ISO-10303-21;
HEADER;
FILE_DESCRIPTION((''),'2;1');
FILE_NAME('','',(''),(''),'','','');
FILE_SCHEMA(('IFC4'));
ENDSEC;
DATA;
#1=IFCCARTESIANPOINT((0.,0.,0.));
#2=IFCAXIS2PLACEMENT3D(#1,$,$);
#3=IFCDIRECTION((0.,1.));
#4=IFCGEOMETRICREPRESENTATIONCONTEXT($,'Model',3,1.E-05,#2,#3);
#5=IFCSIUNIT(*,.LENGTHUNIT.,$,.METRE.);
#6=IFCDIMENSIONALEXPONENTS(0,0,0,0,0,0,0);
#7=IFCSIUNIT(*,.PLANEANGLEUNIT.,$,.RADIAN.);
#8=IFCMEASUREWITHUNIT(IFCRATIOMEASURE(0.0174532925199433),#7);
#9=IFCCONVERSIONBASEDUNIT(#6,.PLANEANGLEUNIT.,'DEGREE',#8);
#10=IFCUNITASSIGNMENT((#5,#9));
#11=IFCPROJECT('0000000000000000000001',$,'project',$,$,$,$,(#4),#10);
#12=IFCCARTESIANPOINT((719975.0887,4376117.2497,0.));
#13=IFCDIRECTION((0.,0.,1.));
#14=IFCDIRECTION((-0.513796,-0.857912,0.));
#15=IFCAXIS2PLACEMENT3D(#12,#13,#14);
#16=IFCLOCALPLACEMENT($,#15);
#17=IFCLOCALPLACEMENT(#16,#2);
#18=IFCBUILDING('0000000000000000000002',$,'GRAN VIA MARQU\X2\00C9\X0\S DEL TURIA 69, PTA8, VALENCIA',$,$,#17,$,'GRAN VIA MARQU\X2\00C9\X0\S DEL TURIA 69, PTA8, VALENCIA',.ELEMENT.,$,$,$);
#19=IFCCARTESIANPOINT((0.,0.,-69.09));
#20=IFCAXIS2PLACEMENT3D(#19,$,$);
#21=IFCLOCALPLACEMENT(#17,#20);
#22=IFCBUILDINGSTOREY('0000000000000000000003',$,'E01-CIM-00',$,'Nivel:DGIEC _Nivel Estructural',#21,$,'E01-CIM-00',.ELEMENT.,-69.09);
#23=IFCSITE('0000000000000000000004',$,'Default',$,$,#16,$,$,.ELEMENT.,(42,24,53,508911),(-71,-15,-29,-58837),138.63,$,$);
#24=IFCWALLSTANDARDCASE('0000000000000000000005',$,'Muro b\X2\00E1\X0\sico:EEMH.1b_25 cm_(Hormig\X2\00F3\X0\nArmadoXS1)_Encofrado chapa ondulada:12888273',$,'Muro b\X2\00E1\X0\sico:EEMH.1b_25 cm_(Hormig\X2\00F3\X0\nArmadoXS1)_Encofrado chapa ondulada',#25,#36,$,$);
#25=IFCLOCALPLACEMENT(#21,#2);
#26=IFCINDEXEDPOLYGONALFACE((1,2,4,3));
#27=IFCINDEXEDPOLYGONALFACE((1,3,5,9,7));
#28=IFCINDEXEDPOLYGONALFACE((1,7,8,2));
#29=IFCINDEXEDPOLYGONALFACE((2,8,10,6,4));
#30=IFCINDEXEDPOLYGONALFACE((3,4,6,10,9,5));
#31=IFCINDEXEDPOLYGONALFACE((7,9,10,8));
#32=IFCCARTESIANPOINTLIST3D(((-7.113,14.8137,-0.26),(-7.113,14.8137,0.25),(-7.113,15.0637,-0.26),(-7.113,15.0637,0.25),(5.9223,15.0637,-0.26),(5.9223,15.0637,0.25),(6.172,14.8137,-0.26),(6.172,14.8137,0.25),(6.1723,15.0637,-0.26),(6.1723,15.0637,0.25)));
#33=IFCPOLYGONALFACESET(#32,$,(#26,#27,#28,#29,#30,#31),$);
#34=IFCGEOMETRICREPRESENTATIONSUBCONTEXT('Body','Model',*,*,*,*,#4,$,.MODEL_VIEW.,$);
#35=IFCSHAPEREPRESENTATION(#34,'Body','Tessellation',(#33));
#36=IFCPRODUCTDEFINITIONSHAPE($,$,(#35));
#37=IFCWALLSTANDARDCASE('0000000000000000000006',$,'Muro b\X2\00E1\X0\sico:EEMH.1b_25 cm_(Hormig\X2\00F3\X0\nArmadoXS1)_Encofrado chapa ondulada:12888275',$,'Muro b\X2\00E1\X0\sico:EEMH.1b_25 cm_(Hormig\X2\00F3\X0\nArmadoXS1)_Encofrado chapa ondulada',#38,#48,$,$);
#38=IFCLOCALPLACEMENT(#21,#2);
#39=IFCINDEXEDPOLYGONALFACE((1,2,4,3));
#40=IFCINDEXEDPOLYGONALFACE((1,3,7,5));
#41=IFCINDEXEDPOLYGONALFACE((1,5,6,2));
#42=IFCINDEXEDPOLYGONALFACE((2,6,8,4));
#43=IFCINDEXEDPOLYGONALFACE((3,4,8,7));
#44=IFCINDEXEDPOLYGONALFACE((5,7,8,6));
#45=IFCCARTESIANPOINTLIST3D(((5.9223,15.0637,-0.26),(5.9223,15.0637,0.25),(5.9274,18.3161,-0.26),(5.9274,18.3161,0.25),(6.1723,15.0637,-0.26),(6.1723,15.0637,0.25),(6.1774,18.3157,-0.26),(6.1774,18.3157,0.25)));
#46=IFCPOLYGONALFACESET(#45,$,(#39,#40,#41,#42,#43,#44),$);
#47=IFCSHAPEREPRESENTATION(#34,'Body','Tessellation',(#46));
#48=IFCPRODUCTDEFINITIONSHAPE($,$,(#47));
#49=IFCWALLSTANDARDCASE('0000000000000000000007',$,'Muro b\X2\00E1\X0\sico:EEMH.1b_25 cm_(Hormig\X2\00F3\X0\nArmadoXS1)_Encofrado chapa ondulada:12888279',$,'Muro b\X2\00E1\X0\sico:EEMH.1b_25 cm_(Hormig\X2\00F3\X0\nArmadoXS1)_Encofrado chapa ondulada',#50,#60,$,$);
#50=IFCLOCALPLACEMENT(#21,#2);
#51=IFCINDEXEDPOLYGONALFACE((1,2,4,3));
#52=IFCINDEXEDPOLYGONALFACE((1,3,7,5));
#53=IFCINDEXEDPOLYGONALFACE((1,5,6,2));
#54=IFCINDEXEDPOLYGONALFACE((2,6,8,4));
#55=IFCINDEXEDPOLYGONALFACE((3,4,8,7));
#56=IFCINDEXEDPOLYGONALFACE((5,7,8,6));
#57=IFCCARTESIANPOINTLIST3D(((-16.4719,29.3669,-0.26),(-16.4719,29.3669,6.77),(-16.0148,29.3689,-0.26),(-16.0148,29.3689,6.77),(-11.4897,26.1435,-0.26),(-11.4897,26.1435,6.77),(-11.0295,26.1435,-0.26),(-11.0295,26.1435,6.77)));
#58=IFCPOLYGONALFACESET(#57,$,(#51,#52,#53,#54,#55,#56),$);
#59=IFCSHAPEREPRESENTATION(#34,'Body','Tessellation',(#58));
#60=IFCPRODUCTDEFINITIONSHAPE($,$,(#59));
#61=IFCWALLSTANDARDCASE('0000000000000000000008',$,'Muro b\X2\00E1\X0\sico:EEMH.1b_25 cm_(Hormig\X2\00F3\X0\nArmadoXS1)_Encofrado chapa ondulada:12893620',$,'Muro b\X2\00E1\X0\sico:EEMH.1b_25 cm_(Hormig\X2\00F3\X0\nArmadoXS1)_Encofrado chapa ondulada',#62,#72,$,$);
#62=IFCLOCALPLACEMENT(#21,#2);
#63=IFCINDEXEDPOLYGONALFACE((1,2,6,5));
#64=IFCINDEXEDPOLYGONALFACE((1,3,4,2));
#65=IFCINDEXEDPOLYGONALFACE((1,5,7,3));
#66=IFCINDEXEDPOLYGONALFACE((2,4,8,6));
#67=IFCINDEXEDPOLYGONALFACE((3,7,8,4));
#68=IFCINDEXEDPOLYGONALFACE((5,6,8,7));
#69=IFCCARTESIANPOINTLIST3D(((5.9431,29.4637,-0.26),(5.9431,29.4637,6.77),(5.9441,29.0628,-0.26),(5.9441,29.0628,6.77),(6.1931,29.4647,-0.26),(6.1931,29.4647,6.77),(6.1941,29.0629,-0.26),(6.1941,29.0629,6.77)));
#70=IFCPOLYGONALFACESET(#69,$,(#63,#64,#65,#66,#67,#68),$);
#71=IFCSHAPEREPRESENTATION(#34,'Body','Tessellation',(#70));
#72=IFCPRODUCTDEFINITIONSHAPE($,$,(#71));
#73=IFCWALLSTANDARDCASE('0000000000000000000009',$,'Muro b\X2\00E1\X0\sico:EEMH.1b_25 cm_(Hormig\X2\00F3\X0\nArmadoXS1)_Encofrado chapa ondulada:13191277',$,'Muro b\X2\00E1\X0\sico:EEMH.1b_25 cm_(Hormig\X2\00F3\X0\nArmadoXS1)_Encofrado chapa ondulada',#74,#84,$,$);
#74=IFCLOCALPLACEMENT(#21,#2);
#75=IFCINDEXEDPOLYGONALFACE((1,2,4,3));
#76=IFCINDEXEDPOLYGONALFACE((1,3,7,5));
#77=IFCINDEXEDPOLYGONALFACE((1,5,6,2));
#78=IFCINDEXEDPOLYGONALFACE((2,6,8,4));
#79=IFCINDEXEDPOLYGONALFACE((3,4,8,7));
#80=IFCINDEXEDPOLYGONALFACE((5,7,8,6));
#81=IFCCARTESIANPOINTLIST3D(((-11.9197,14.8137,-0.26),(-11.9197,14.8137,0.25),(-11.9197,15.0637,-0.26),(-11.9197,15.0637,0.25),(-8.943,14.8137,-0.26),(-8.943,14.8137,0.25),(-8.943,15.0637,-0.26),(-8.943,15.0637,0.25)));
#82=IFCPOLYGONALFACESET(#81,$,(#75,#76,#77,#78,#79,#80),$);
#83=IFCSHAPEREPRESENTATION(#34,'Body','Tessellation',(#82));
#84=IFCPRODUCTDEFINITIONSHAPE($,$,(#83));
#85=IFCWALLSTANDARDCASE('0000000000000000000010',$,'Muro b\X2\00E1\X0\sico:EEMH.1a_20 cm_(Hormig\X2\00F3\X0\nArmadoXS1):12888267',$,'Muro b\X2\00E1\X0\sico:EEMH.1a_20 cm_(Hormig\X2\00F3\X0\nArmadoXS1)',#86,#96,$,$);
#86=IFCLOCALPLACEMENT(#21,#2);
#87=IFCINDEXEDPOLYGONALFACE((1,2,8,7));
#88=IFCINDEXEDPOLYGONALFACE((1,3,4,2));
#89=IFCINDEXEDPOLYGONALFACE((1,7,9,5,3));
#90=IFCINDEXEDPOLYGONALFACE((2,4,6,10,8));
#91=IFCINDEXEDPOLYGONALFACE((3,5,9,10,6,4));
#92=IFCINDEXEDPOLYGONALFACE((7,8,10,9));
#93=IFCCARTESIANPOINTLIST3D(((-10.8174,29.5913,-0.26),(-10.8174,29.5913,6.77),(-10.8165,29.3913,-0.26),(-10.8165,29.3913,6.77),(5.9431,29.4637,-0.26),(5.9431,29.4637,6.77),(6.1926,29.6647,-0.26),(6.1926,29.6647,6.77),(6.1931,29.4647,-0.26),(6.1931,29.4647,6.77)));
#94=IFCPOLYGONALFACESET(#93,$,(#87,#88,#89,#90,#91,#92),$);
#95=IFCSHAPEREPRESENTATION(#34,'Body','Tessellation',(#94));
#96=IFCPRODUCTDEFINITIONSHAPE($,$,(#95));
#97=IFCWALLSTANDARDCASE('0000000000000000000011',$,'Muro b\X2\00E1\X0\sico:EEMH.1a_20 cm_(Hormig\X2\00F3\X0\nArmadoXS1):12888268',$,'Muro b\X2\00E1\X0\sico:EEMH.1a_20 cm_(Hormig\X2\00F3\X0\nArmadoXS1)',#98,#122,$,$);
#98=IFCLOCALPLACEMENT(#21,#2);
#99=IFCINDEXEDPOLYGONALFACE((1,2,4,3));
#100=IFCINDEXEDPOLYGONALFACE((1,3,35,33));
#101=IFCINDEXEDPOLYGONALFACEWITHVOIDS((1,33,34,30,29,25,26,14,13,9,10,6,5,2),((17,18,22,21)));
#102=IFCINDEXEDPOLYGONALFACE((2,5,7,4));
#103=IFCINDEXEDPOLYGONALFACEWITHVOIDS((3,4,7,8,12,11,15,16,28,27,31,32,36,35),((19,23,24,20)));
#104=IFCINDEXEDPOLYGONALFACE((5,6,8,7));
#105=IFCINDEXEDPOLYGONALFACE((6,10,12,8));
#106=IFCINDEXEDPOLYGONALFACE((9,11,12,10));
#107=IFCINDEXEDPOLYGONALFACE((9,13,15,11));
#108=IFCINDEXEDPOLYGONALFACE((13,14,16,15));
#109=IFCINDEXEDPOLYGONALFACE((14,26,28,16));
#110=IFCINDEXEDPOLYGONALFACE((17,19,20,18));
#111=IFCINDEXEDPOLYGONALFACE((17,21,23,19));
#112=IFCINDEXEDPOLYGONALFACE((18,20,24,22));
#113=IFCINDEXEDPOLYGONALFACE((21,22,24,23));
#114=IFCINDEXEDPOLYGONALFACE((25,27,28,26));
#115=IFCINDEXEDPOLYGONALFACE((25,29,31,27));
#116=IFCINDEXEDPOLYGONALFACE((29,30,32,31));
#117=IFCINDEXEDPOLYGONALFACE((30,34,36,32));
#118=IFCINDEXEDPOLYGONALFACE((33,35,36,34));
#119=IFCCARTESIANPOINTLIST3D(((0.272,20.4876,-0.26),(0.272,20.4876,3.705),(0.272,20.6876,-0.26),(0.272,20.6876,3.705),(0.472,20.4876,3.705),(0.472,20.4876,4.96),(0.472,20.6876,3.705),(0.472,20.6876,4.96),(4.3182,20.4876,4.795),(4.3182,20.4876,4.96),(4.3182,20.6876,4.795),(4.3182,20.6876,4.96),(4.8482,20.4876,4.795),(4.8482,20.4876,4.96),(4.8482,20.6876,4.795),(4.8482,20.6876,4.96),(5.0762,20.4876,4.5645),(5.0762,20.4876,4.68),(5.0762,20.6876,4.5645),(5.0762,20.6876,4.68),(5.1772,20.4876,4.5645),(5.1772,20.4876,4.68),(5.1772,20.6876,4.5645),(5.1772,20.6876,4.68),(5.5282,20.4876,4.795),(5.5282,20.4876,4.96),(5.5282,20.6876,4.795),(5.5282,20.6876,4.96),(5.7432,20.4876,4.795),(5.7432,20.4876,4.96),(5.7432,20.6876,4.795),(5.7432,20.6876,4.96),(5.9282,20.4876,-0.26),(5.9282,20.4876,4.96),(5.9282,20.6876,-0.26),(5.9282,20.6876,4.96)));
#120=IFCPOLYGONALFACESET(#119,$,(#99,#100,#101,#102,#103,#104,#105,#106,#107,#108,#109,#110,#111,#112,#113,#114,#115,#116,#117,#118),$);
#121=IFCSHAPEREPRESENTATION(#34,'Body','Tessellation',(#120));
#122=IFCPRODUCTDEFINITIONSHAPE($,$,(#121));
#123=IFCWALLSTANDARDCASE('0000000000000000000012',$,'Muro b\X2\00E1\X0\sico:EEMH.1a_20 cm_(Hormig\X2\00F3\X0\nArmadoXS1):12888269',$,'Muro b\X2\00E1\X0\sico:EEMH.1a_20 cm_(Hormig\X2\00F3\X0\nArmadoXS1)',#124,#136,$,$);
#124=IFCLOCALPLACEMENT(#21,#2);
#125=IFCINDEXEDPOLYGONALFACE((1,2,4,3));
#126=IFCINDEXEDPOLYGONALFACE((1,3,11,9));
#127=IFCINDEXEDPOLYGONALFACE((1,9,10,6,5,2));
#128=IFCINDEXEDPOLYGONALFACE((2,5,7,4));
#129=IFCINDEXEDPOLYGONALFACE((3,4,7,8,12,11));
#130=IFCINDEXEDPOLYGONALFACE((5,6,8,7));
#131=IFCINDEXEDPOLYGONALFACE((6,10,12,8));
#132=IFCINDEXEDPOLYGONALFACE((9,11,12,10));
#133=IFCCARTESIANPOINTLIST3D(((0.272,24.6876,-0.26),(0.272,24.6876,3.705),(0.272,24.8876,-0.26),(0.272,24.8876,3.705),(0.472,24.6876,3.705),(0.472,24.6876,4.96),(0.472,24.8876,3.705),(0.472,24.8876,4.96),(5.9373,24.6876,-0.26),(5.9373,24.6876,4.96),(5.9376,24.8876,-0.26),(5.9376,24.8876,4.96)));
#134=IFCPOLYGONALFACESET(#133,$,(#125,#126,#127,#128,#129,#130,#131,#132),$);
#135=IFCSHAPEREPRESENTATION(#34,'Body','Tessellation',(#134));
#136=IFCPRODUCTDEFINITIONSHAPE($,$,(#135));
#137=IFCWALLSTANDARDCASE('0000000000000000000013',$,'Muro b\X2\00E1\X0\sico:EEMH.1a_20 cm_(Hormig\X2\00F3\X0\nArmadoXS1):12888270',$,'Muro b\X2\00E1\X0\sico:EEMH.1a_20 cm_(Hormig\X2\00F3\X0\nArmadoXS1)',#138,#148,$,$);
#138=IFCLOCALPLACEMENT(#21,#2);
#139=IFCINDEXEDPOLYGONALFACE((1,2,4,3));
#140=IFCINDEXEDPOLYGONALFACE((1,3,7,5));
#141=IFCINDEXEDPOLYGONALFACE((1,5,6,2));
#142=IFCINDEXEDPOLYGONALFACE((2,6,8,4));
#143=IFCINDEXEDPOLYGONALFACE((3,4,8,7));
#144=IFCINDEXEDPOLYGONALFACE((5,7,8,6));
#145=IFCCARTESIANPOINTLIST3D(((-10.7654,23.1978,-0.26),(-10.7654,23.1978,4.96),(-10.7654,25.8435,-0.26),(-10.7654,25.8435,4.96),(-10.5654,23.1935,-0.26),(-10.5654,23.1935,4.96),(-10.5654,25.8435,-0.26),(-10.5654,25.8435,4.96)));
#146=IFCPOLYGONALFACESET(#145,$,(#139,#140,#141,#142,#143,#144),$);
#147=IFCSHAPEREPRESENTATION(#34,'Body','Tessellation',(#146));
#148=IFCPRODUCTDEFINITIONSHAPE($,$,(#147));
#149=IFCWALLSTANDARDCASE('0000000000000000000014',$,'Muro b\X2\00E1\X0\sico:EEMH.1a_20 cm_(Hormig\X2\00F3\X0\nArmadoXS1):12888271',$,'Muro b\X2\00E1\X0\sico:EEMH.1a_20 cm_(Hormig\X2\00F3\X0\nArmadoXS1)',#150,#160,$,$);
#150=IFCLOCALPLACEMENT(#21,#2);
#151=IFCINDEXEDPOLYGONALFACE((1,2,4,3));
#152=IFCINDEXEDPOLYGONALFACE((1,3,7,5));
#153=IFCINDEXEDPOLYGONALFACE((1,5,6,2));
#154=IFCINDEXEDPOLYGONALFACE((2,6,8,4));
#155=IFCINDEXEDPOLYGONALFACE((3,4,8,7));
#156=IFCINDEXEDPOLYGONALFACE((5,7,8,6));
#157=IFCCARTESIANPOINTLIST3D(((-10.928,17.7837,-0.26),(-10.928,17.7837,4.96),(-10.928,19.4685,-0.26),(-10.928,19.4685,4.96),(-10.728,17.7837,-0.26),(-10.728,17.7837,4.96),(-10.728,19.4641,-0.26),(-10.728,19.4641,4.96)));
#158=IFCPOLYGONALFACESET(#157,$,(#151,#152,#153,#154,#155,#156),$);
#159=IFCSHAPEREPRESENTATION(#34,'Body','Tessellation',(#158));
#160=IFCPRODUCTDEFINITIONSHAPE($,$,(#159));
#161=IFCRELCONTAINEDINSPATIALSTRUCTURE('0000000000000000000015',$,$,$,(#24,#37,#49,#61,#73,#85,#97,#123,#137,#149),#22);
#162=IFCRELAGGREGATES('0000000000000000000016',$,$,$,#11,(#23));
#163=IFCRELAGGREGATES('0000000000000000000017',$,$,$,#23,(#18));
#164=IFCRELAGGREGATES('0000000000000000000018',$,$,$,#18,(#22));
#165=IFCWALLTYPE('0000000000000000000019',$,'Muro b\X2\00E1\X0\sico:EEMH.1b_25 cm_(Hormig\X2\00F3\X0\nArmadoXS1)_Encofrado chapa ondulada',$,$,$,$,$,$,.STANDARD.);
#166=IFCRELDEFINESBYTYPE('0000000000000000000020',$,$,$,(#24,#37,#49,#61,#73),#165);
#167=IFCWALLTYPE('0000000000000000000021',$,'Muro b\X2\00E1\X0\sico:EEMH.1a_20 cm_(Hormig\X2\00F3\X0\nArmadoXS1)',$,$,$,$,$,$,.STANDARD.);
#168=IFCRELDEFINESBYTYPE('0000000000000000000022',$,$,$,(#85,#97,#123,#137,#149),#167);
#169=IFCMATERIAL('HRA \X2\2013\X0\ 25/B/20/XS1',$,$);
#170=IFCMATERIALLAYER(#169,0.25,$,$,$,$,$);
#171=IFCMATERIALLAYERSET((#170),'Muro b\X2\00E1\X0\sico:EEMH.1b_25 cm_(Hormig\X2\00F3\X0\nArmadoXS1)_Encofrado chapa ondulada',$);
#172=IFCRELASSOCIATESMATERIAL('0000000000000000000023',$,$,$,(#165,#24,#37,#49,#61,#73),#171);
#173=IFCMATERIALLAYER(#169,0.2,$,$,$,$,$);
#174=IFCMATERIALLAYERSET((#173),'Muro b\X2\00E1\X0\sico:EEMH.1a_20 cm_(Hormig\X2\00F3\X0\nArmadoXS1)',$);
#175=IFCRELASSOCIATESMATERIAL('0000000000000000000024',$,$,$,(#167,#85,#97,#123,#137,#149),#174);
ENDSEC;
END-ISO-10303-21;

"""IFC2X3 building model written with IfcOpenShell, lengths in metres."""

from ifc_helpers import new_model, entity, si_unit, converted_unit, direction, frame, frame_2d, origin, origin_2d_with_axis, place, context, subcontext, project, spatial, polyline, rectangle, outline, extrude, clip, bounded_halfspace, material, layer, layer_set, layer_usage, type_object, element, save


model = new_model("IFC2X3")

# Units and contexts
model_context = context("Model", 3, precision=1e-05, world=origin(), true_north=direction((0.0, 1.0)))
body_context = subcontext(model_context, "Body", "Model", "MODEL_VIEW")
ifc_project = project(units=[si_unit("LENGTHUNIT", "METRE"), converted_unit("PLANEANGLEUNIT", "DEGREE", entity("IfcRatioMeasure", 0.0174532925199433), si_unit("PLANEANGLEUNIT", "RADIAN"), dimensions=[0, 0, 0, 0, 0, 0, 0])], contexts=[model_context])

# Site, building, storey
site_placement = place(None, frame((719975.0887, 4376117.2497, 0.0), z_axis=(0.0, 0.0, 1.0), x_axis=(-0.513796, -0.857912, 0.0)))
site = spatial("IfcSite", under=ifc_project, at=site_placement, Name="Default", CompositionType="ELEMENT", RefLatitude=(42, 24, 53, 508911), RefLongitude=(-71, -15, -29, -58837), RefElevation=138.63)
building_placement = place(site_placement, origin())
building = spatial("IfcBuilding", under=site, at=building_placement, Name="GRAN VIA MARQUÉS DEL TURIA 69, PTA8, VALENCIA", LongName="GRAN VIA MARQUÉS DEL TURIA 69, PTA8, VALENCIA", CompositionType="ELEMENT")
storey_placement = place(building_placement, frame((0.0, 0.0, -69.09)))
storey = spatial("IfcBuildingStorey", under=building, at=storey_placement, Name="E01-CIM-00", ObjectType="Nivel:DGIEC _Nivel Estructural", LongName="E01-CIM-00", CompositionType="ELEMENT", Elevation=-69.09)

# Walls
ifc_material_1 = material(Name="HRA – 25/B/20/XS1")
ifc_layer_1 = layer(ifc_material_1, 0.25)
ifc_layer_set_1 = layer_set([ifc_layer_1], Name="Muro básico:EEMH.1b_25 cm_(HormigónArmadoXS1)_Encofrado chapa ondulada")
ifc_layer_usage_1 = layer_usage(ifc_layer_set_1, "AXIS2", "NEGATIVE", 0.125)
wall_type_1 = type_object("IfcWallType", Name="Muro básico:EEMH.1b_25 cm_(HormigónArmadoXS1)_Encofrado chapa ondulada", PredefinedType="STANDARD", material=ifc_layer_set_1)
wall_1_placement = place(storey_placement, frame((6.1723, 14.9387, -0.26), z_axis=(0.0, 0.0, 1.0), x_axis=(-1.0, 0.0, 0.0)))
element("IfcWallStandardCase", 1, at=wall_1_placement, inside=storey, type_object=wall_type_1, material=ifc_layer_usage_1, Name="Muro básico:EEMH.1b_25 cm_(HormigónArmadoXS1)_Encofrado chapa ondulada:12888273", ObjectType="Muro básico:EEMH.1b_25 cm_(HormigónArmadoXS1)_Encofrado chapa ondulada", context=body_context, shape_type="SweptSolid", body=[
    extrude(outline(polyline([(13.2854, -0.125), (13.2854, 0.125), (0.0004, 0.125), (0.0, -0.125), (0.25, -0.125), (13.2854, -0.125)])), origin(), (0.0, 0.0, 1.0), 0.51),
])
ifc_layer_usage_2 = layer_usage(ifc_layer_set_1, "AXIS2", "NEGATIVE", 0.125)
wall_2_placement = place(storey_placement, frame((6.0524, 18.3159, -0.26), z_axis=(0.0, 0.0, 1.0), x_axis=(-0.001551, -0.999999, 0.0)))
element("IfcWallStandardCase", 2, at=wall_2_placement, inside=storey, type_object=wall_type_1, material=ifc_layer_usage_2, Name="Muro básico:EEMH.1b_25 cm_(HormigónArmadoXS1)_Encofrado chapa ondulada:12888275", ObjectType="Muro básico:EEMH.1b_25 cm_(HormigónArmadoXS1)_Encofrado chapa ondulada", context=body_context, shape_type="SweptSolid", body=[
    extrude(outline(polyline([(3.2523, -0.125), (3.252, 0.125), (0.0, 0.125), (0.0, -0.125), (3.2523, -0.125)])), origin(), (0.0, 0.0, 1.0), 0.51),
])
ifc_layer_usage_3 = layer_usage(ifc_layer_set_1, "AXIS2", "NEGATIVE", 0.125)
wall_3_placement = place(storey_placement, frame((-11.0974, 26.0386, -0.26), z_axis=(0.0, 0.0, 1.0), x_axis=(-0.839602, 0.543202, 0.0)))
element("IfcWallStandardCase", 3, at=wall_3_placement, inside=storey, type_object=wall_type_1, material=ifc_layer_usage_3, Name="Muro básico:EEMH.1b_25 cm_(HormigónArmadoXS1)_Encofrado chapa ondulada:12888279", ObjectType="Muro básico:EEMH.1b_25 cm_(HormigónArmadoXS1)_Encofrado chapa ondulada", context=body_context, shape_type="SweptSolid", body=[
    extrude(outline(polyline([(5.9376, -0.125), (6.3204, 0.125), (0.3864, 0.125), (0.0, -0.125), (5.9376, -0.125)])), origin(), (0.0, 0.0, 1.0), 7.03),
])
ifc_layer_usage_4 = layer_usage(ifc_layer_set_1, "AXIS2", "NEGATIVE", 0.125)
wall_4_placement = place(storey_placement, frame((6.0681, 29.4644, -0.26), z_axis=(0.0, 0.0, 1.0), x_axis=(0.002447, -0.999997, 0.0)))
element("IfcWallStandardCase", 4, at=wall_4_placement, inside=storey, type_object=wall_type_1, material=ifc_layer_usage_4, Name="Muro básico:EEMH.1b_25 cm_(HormigónArmadoXS1)_Encofrado chapa ondulada:12893620", ObjectType="Muro básico:EEMH.1b_25 cm_(HormigónArmadoXS1)_Encofrado chapa ondulada", context=body_context, shape_type="SweptSolid", body=[
    extrude(outline(polyline([(0.4013, -0.125), (0.4018, 0.125), (0.0, 0.125), (0.0005, -0.125), (0.4013, -0.125)])), origin(), (0.0, 0.0, 1.0), 7.03),
])
ifc_layer_usage_5 = layer_usage(ifc_layer_set_1, "AXIS2", "NEGATIVE", 0.125)
wall_5_placement = place(storey_placement, frame((-8.943, 14.9387, -0.26), z_axis=(0.0, 0.0, 1.0), x_axis=(-1.0, 0.0, 0.0)))
element("IfcWallStandardCase", 5, at=wall_5_placement, inside=storey, type_object=wall_type_1, material=ifc_layer_usage_5, Name="Muro básico:EEMH.1b_25 cm_(HormigónArmadoXS1)_Encofrado chapa ondulada:13191277", ObjectType="Muro básico:EEMH.1b_25 cm_(HormigónArmadoXS1)_Encofrado chapa ondulada", context=body_context, shape_type="SweptSolid", body=[
    extrude(rectangle(XDim=2.9767, YDim=0.25, at=frame_2d((1.4883, 0.0), x_axis=(-1.0, 0.0))), origin(), (0.0, 0.0, 1.0), 0.51),
])
ifc_layer_2 = layer(ifc_material_1, 0.2)
ifc_layer_set_2 = layer_set([ifc_layer_2], Name="Muro básico:EEMH.1a_20 cm_(HormigónArmadoXS1)")
ifc_layer_usage_6 = layer_usage(ifc_layer_set_2, "AXIS2", "NEGATIVE", 0.1)
wall_type_2 = type_object("IfcWallType", Name="Muro básico:EEMH.1a_20 cm_(HormigónArmadoXS1)", PredefinedType="STANDARD", material=ifc_layer_set_2)
wall_6_placement = place(storey_placement, frame((6.193, 29.5647, -0.26), z_axis=(0.0, 0.0, 1.0), x_axis=(-0.999991, -0.004316, 0.0)))
element("IfcWallStandardCase", 6, at=wall_6_placement, inside=storey, type_object=wall_type_2, material=ifc_layer_usage_6, Name="Muro básico:EEMH.1a_20 cm_(HormigónArmadoXS1):12888267", ObjectType="Muro básico:EEMH.1a_20 cm_(HormigónArmadoXS1)", context=body_context, shape_type="SweptSolid", body=[
    extrude(outline(polyline([(17.0101, -0.1), (17.0101, 0.1), (0.2504, 0.1), (0.0004, 0.1), (0.0, -0.1), (17.0101, -0.1)])), origin(), (0.0, 0.0, 1.0), 7.03),
])

# Wall, openings
ifc_layer_usage_7 = layer_usage(ifc_layer_set_2, "AXIS2", "NEGATIVE", 0.1)
wall_7_placement = place(storey_placement, frame((0.272, 20.5876, -0.26)))
wall_7 = element("IfcWallStandardCase", 7, at=wall_7_placement, inside=storey, type_object=wall_type_2, material=ifc_layer_usage_7, Name="Muro básico:EEMH.1a_20 cm_(HormigónArmadoXS1):12888268", ObjectType="Muro básico:EEMH.1a_20 cm_(HormigónArmadoXS1)", context=body_context, shape_type="Clipping", body=[
    clip(clip(extrude(rectangle(XDim=5.6562, YDim=0.2, at=frame_2d((2.8281, 0.0), x_axis=(-1.0, 0.0))), origin(), (0.0, 0.0, 1.0), 5.22), bounded_halfspace(frame((0.2, 0.1, 3.965), z_axis=(1.0, 0.0, 0.0), x_axis=(0.0, 1.0, 0.0)), True, frame((0.2, 0.1, 3.965), z_axis=(1.0, 0.0, 0.0), x_axis=(0.0, 1.0, 0.0)), polyline([(0.0, 0.0), (0.0, 1.255), (-0.2, 1.255), (-0.2, 0.0), (0.0, 0.0)]))), bounded_halfspace(frame((0.2, -0.1, 3.965), z_axis=(0.0, 0.0, -1.0), x_axis=(-1.0, 0.0, 0.0)), True, frame((0.2, -0.1, 3.965), z_axis=(0.0, 0.0, -1.0), x_axis=(-1.0, 0.0, 0.0)), polyline([(0.0, 0.0), (0.2, 0.0), (0.2, 0.2), (0.0, 0.2), (0.0, 0.0)]))),
])
opening_1_placement = place(wall_7_placement, origin())
element("IfcOpeningElement", 8, at=opening_1_placement, cuts=wall_7, ObjectType="Opening", context=body_context, shape_type="SweptSolid", body=[
    extrude(rectangle(XDim=0.165, YDim=0.215, at=frame_2d((0.0, 0.0), x_axis=(1.0, 0.0))), frame((5.3637, -0.1, 5.1375), z_axis=(0.0, 1.0, 0.0), x_axis=(0.0, 0.0, -1.0)), (0.0, 0.0, 1.0), 0.2),
])
opening_2_placement = place(wall_7_placement, origin())
element("IfcOpeningElement", 9, at=opening_2_placement, cuts=wall_7, ObjectType="Opening", context=body_context, shape_type="SweptSolid", body=[
    extrude(rectangle(XDim=0.1155, YDim=0.101, at=origin_2d_with_axis()), frame((4.8547, -0.1, 4.8823), z_axis=(0.0, 1.0, 0.0), x_axis=(0.0, 0.0, -1.0)), (0.0, 0.0, 1.0), 0.2),
])
opening_3_placement = place(wall_7_placement, origin())
element("IfcOpeningElement", 10, at=opening_3_placement, cuts=wall_7, ObjectType="Opening", context=body_context, shape_type="SweptSolid", body=[
    extrude(rectangle(XDim=0.165, YDim=0.53, at=frame_2d((0.0, 0.0), x_axis=(1.0, 0.0))), frame((4.3112, -0.1, 5.1375), z_axis=(0.0, 1.0, 0.0), x_axis=(0.0, 0.0, -1.0)), (0.0, 0.0, 1.0), 0.2),
])

# Walls
ifc_layer_usage_8 = layer_usage(ifc_layer_set_2, "AXIS2", "NEGATIVE", 0.1)
wall_8_placement = place(storey_placement, frame((0.272, 24.7876, -0.26)))
element("IfcWallStandardCase", 11, at=wall_8_placement, inside=storey, type_object=wall_type_2, material=ifc_layer_usage_8, Name="Muro básico:EEMH.1a_20 cm_(HormigónArmadoXS1):12888269", ObjectType="Muro básico:EEMH.1a_20 cm_(HormigónArmadoXS1)", context=body_context, shape_type="Clipping", body=[
    clip(clip(extrude(outline(polyline([(5.6653, -0.1), (5.6656, 0.1), (0.0, 0.1), (0.0, -0.1), (5.6653, -0.1)])), origin(), (0.0, 0.0, 1.0), 5.22), bounded_halfspace(frame((0.2, 0.1, 3.965), z_axis=(1.0, 0.0, 0.0), x_axis=(0.0, 1.0, 0.0)), True, frame((0.2, 0.1, 3.965), z_axis=(1.0, 0.0, 0.0), x_axis=(0.0, 1.0, 0.0)), polyline([(0.0, 0.0), (0.0, 1.255), (-0.2, 1.255), (-0.2, 0.0), (0.0, 0.0)]))), bounded_halfspace(frame((0.2, -0.1, 3.965), z_axis=(0.0, 0.0, -1.0), x_axis=(-1.0, 0.0, 0.0)), True, frame((0.2, -0.1, 3.965), z_axis=(0.0, 0.0, -1.0), x_axis=(-1.0, 0.0, 0.0)), polyline([(0.0, 0.0), (0.2, 0.0), (0.2, 0.2), (0.0, 0.2), (0.0, 0.0)]))),
])
ifc_layer_usage_9 = layer_usage(ifc_layer_set_2, "AXIS2", "NEGATIVE", 0.1)
wall_9_placement = place(storey_placement, frame((-10.6654, 23.1935, -0.26), z_axis=(0.0, 0.0, 1.0), x_axis=(0.0, 1.0, 0.0)))
element("IfcWallStandardCase", 12, at=wall_9_placement, inside=storey, type_object=wall_type_2, material=ifc_layer_usage_9, Name="Muro básico:EEMH.1a_20 cm_(HormigónArmadoXS1):12888270", ObjectType="Muro básico:EEMH.1a_20 cm_(HormigónArmadoXS1)", context=body_context, shape_type="SweptSolid", body=[
    extrude(outline(polyline([(2.6501, -0.1), (2.6501, 0.1), (0.0044, 0.1), (0.0, -0.1), (2.6501, -0.1)])), origin(), (0.0, 0.0, 1.0), 5.22),
])
ifc_layer_usage_10 = layer_usage(ifc_layer_set_2, "AXIS2", "NEGATIVE", 0.1)
wall_10_placement = place(storey_placement, frame((-10.828, 17.7837, -0.26), z_axis=(0.0, 0.0, 1.0), x_axis=(0.0, 1.0, 0.0)))
element("IfcWallStandardCase", 13, at=wall_10_placement, inside=storey, type_object=wall_type_2, material=ifc_layer_usage_10, Name="Muro básico:EEMH.1a_20 cm_(HormigónArmadoXS1):12888271", ObjectType="Muro básico:EEMH.1a_20 cm_(HormigónArmadoXS1)", context=body_context, shape_type="SweptSolid", body=[
    extrude(outline(polyline([(1.6804, -0.1), (1.6848, 0.1), (0.0, 0.1), (0.0, -0.1), (1.6804, -0.1)])), origin(), (0.0, 0.0, 1.0), 5.22),
])

save(model, "model.ifc")
